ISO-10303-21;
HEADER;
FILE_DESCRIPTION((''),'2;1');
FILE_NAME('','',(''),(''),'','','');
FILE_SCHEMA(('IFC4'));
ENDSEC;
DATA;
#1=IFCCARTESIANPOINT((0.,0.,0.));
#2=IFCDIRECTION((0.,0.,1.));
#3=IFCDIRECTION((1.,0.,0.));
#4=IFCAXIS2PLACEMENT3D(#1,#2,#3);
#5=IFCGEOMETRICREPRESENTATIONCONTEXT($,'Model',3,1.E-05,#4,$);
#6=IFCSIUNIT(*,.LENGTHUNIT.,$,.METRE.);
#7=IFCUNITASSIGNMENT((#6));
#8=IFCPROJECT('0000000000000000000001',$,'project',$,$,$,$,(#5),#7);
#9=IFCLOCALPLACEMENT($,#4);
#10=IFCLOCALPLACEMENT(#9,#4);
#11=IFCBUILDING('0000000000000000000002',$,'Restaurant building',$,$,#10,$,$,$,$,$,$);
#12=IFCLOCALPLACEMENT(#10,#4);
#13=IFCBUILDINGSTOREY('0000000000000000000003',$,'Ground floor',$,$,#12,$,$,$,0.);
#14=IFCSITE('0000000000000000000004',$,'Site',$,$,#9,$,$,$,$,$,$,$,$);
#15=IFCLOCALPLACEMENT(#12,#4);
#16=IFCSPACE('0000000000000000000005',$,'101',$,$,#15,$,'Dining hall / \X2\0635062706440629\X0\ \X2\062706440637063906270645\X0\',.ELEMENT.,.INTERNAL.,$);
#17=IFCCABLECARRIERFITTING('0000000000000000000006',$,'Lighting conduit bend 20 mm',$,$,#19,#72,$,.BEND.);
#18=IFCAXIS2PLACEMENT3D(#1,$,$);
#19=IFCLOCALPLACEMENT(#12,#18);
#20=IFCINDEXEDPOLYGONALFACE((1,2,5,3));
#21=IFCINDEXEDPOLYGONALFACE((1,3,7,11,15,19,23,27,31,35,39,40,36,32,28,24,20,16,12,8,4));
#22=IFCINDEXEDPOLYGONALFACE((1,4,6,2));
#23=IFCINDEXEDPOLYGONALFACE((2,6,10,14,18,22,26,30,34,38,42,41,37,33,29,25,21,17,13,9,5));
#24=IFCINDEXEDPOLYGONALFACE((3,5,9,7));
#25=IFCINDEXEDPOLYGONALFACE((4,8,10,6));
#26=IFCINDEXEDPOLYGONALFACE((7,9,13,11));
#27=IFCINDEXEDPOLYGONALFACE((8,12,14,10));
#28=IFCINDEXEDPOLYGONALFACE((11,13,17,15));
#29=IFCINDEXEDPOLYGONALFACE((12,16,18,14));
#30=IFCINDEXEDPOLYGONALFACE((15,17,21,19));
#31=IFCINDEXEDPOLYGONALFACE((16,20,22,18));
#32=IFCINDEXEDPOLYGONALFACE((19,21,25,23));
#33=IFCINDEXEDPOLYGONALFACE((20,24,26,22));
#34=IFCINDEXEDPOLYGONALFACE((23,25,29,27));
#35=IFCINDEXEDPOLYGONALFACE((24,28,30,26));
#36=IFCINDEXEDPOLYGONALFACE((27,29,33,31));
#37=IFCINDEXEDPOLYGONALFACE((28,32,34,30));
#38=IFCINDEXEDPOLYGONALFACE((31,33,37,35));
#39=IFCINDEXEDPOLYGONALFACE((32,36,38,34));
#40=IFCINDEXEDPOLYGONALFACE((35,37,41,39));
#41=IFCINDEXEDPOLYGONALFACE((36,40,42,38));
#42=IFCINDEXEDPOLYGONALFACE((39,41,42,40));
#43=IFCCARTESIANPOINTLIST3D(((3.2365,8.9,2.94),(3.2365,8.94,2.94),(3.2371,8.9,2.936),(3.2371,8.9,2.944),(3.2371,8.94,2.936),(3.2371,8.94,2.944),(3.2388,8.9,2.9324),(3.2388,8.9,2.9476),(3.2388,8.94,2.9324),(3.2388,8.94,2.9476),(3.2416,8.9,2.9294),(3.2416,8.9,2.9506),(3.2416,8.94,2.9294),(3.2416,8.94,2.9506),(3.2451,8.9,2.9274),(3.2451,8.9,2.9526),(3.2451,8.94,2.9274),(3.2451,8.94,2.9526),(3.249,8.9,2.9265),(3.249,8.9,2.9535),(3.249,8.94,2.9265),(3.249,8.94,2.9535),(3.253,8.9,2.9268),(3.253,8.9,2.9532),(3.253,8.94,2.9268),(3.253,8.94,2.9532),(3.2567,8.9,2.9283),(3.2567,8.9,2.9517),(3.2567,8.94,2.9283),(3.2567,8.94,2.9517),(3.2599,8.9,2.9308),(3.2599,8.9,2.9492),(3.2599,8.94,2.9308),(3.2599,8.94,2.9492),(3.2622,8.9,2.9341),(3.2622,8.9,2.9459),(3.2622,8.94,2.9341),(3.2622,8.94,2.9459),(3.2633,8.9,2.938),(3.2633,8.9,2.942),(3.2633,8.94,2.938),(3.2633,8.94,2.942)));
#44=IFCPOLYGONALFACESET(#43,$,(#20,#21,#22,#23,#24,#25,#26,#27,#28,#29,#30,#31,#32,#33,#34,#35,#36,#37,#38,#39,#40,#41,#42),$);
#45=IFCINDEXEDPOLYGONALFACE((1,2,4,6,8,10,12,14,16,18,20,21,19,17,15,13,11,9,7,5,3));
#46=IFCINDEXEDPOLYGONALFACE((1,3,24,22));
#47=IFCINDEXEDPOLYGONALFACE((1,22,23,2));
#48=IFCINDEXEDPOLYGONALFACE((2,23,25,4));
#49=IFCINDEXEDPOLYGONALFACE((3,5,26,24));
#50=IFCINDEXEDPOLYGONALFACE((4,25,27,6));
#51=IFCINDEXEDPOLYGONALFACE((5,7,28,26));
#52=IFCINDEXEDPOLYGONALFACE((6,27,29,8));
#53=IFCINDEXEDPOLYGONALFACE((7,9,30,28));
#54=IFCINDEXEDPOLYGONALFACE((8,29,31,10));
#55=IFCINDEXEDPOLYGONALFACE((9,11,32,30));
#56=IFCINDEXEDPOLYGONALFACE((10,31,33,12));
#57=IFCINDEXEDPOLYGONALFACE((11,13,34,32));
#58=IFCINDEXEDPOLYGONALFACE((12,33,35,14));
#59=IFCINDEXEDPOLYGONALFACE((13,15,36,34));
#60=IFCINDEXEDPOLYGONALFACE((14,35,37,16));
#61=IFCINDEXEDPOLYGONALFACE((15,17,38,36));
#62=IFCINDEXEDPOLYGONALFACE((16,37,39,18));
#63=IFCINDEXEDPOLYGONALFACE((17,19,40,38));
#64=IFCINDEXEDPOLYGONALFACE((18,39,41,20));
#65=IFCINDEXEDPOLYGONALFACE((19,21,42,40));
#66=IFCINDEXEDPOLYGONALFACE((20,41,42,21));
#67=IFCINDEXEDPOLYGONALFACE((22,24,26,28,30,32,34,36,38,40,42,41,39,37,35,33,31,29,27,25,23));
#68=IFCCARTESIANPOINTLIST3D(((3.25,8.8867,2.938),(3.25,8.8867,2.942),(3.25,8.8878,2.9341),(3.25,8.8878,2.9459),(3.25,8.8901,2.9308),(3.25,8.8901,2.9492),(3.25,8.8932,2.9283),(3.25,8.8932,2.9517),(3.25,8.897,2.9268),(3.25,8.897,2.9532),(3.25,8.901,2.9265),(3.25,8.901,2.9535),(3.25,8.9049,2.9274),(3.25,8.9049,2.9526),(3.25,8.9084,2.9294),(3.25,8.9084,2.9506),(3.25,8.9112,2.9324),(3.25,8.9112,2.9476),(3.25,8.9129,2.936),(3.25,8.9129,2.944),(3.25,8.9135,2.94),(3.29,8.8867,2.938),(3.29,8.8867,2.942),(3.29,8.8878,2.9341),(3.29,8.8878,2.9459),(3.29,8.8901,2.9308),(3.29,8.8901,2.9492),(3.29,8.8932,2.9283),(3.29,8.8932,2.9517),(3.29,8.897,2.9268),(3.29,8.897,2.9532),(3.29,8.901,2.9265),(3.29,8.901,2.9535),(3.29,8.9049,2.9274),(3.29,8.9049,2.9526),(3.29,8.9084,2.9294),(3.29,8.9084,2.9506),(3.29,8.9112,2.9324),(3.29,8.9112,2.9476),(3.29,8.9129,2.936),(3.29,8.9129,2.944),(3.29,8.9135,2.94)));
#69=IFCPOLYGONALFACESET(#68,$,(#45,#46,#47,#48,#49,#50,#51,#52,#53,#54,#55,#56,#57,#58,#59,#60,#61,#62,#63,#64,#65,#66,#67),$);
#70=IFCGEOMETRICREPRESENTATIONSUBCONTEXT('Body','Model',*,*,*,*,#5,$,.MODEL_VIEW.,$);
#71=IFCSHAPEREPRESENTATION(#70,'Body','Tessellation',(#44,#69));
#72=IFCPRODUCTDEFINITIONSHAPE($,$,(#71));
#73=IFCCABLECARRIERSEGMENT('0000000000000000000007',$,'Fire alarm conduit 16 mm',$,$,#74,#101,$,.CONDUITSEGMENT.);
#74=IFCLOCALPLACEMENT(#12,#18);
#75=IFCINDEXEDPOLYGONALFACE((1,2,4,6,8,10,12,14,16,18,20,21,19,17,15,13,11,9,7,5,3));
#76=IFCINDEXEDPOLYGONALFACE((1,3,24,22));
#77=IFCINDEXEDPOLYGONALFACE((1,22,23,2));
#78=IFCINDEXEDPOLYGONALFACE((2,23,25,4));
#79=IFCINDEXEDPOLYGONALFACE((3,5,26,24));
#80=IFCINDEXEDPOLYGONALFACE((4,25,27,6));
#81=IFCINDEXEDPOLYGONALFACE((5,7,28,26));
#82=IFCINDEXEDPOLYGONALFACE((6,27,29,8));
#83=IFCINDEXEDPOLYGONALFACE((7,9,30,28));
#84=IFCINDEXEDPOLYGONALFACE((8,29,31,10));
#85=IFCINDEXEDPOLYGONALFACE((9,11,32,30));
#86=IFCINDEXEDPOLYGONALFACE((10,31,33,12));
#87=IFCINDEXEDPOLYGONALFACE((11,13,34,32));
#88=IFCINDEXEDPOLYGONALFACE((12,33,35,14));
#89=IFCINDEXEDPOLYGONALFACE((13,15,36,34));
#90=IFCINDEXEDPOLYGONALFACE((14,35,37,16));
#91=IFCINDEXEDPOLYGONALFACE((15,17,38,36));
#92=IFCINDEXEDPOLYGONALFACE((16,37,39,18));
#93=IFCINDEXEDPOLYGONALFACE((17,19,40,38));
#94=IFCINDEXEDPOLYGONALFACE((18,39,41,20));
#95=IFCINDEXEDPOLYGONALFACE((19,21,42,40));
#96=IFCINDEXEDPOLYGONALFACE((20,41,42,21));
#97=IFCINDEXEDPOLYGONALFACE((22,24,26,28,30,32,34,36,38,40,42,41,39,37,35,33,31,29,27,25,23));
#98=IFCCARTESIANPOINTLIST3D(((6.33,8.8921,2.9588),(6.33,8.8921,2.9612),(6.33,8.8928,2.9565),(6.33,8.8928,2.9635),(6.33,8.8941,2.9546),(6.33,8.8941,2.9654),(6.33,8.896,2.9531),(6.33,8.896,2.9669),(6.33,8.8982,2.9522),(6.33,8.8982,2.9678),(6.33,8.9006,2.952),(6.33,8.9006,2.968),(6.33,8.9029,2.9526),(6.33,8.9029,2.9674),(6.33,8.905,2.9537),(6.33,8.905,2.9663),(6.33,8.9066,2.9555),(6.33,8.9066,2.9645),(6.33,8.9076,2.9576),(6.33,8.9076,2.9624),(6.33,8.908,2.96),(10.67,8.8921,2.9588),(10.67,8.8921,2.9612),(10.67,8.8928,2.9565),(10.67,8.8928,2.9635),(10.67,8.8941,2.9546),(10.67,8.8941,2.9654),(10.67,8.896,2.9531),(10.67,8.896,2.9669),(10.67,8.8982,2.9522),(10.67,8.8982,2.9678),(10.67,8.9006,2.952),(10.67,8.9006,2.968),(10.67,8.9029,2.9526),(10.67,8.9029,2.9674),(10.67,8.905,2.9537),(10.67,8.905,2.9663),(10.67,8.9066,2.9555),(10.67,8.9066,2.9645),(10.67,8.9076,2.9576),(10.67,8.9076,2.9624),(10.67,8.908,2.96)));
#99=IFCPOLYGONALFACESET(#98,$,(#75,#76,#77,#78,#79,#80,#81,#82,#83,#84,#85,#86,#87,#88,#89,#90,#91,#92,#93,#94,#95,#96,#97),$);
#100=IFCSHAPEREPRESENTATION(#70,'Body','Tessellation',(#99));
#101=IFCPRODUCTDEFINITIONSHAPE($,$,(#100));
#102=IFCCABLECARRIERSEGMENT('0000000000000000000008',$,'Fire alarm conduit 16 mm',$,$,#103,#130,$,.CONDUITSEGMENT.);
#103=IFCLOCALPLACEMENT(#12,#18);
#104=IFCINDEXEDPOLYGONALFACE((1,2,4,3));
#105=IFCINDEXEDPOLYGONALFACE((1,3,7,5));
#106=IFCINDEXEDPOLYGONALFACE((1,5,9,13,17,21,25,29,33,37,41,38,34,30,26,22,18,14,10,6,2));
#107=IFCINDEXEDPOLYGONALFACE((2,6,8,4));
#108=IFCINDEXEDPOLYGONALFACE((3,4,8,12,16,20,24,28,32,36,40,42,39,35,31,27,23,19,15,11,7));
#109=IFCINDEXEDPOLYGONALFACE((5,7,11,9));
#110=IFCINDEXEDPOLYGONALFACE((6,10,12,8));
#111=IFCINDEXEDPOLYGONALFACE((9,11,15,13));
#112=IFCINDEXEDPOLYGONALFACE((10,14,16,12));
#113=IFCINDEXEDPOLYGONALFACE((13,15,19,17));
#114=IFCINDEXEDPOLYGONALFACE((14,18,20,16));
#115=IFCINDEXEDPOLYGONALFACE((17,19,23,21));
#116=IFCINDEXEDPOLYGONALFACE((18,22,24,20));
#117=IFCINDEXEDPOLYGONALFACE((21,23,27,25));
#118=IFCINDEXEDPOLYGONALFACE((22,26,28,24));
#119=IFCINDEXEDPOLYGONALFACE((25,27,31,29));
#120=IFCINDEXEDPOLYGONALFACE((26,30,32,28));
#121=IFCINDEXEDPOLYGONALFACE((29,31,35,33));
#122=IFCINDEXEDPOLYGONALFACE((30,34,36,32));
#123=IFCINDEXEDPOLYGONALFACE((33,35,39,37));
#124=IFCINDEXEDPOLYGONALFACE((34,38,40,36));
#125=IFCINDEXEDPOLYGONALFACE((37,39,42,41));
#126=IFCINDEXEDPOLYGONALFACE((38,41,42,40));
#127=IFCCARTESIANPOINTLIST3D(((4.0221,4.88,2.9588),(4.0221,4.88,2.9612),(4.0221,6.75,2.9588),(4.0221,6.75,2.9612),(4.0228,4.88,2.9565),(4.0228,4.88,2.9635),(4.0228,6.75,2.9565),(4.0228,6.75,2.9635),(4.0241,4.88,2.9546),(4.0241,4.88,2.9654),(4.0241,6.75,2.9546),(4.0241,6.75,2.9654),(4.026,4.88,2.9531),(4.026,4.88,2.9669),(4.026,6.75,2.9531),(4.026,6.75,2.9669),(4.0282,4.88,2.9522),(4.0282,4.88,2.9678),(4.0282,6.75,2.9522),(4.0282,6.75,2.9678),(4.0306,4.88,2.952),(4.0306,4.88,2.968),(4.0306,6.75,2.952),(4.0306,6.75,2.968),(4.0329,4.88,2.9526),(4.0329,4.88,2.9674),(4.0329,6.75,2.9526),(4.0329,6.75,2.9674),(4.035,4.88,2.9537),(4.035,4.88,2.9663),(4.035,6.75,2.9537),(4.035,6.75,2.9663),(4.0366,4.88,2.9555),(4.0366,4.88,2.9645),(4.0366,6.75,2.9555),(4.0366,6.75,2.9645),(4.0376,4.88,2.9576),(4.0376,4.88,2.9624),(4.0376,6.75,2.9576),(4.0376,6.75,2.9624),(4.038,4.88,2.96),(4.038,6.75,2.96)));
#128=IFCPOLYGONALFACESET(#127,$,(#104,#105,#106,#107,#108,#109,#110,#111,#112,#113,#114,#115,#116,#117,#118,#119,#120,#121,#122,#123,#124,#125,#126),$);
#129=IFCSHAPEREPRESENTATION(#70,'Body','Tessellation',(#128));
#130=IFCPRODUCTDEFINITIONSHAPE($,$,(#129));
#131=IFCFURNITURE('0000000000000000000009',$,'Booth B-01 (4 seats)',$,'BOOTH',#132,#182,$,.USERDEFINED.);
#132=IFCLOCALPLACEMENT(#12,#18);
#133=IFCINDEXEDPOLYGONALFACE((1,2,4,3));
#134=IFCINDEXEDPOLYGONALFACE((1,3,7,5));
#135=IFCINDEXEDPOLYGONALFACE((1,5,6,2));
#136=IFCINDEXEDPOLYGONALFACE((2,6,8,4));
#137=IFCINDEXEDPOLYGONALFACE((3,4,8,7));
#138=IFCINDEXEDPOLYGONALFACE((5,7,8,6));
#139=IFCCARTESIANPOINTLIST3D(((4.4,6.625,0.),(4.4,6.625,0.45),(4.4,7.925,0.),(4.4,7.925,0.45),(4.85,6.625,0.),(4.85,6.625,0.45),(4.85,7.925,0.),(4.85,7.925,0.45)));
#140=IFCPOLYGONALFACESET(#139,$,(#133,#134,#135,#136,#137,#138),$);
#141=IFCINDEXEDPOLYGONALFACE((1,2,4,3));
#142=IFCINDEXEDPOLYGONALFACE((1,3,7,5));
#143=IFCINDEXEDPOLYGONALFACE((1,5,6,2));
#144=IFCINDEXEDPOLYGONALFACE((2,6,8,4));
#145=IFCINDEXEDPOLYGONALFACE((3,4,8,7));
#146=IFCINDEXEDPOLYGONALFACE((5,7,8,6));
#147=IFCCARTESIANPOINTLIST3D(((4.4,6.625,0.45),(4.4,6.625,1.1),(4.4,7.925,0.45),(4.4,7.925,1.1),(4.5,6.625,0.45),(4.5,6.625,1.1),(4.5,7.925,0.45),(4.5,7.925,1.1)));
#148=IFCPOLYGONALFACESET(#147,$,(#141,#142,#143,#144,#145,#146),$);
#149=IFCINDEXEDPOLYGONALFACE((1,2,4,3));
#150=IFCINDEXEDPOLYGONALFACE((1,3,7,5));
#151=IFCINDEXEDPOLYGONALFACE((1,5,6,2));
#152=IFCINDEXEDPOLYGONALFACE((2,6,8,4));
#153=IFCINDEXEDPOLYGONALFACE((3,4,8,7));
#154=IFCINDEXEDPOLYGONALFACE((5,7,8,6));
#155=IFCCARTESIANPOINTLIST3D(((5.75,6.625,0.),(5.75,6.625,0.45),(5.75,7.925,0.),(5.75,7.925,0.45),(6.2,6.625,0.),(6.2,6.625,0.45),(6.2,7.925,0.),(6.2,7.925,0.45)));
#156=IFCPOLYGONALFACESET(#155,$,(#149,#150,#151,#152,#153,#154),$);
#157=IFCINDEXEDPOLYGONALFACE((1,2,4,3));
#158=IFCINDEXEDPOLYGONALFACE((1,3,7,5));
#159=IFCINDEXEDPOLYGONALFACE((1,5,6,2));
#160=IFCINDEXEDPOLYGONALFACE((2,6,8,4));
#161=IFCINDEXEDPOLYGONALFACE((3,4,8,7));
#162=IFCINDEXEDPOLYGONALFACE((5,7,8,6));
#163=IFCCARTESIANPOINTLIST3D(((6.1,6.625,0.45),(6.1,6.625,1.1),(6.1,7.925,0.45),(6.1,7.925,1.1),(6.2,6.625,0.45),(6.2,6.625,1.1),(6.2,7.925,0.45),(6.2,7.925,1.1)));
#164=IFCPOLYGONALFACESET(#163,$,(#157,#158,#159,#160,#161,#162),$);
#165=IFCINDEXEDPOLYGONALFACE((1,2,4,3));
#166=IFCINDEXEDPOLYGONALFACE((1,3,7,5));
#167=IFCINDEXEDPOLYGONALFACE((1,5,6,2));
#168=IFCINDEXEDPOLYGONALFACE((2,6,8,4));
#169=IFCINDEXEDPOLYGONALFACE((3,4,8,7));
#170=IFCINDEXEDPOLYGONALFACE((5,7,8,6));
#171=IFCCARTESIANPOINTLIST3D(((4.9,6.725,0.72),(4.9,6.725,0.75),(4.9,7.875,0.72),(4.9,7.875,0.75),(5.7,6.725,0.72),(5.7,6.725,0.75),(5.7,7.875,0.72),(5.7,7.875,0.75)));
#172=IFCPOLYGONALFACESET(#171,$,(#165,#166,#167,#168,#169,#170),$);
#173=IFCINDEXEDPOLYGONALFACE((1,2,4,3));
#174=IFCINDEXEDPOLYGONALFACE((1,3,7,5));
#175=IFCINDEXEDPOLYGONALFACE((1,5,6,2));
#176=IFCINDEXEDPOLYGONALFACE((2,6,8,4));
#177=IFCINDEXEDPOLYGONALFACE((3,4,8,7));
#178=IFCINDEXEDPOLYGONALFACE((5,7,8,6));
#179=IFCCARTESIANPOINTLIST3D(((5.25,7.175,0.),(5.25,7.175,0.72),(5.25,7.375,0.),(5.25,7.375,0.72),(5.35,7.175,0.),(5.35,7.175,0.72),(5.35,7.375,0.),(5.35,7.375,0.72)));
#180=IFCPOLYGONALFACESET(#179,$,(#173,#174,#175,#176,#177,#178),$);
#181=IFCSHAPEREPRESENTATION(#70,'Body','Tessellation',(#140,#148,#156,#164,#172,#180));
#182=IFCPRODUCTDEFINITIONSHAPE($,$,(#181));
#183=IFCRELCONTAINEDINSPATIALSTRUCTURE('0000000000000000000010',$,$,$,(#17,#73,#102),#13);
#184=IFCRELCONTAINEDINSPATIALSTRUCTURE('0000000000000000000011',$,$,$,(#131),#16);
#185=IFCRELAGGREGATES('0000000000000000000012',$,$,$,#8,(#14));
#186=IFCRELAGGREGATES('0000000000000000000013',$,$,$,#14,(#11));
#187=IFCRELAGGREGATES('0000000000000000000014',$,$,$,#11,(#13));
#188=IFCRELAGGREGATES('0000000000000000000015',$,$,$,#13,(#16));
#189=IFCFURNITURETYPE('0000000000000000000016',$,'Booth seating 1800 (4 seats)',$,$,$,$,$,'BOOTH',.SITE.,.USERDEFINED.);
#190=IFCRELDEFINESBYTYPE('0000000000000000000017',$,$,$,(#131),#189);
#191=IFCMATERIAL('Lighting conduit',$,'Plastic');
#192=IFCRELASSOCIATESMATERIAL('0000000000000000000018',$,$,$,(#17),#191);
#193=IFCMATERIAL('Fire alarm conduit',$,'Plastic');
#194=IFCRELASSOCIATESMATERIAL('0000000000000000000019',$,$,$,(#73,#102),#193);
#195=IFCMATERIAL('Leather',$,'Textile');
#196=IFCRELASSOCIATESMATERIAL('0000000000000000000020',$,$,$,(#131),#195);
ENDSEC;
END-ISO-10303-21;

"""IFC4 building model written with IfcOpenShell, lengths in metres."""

from ifc_helpers import new_model, si_unit, frame, origin, origin_with_axes, origin_2d, place, context, subcontext, project, spatial, rectangle, circle, extrude, source, transform, mapped, material, type_object, type_shapes, element, save


model = new_model("IFC4")

# Units and contexts
model_context = context("Model", 3, precision=1e-05, world=origin_with_axes())
body_context = subcontext(model_context, "Body", "Model", "MODEL_VIEW")
ifc_project = project(units=[si_unit("LENGTHUNIT", "METRE")], contexts=[model_context])

# Site, building, storey
site_placement = place(None, origin_with_axes())
site = spatial("IfcSite", under=ifc_project, at=site_placement, Name="Site")
building_placement = place(site_placement, origin_with_axes())
building = spatial("IfcBuilding", under=site, at=building_placement, Name="Restaurant building")
storey_placement = place(building_placement, origin_with_axes())
storey = spatial("IfcBuildingStorey", under=building, at=storey_placement, Name="Ground floor", Elevation=0.0)

# Shared definitions
space_1_placement = place(storey_placement, origin_with_axes())
space_1 = spatial("IfcSpace", under=storey, at=space_1_placement, Name="101", LongName="Dining hall / صالة الطعام", CompositionType="ELEMENT", PredefinedType="INTERNAL")

# Shared definitions
ifc_material_1 = material(Name="Lighting conduit", Category="Plastic")

# Cable carrier fitting
cable_carrier_fitting_1_placement = place(storey_placement, frame((3.25, 8.9, 2.94)))
element("IfcCableCarrierFitting", 1, at=cable_carrier_fitting_1_placement, inside=storey, material=ifc_material_1, Name="Lighting conduit bend 20 mm", PredefinedType="BEND", context=body_context, shape_type="SweptSolid", body=[
    extrude(circle(Radius=0.0135, at=origin_2d()), frame((0.0, 0.0, 0.0), z_axis=(0.0, 1.0, 0.0), x_axis=(-1.0, 0.0, 0.0)), (0.0, 0.0, 1.0), 0.04),
    extrude(circle(Radius=0.0135, at=origin_2d()), frame((0.0, 0.0, 0.0), z_axis=(1.0, 0.0, 0.0), x_axis=(0.0, 1.0, 0.0)), (0.0, 0.0, 1.0), 0.04),
])

# Cable carrier segments
ifc_material_2 = material(Name="Fire alarm conduit", Category="Plastic")
cable_carrier_segment_1_placement = place(storey_placement, frame((6.33, 8.9, 2.96)))
element("IfcCableCarrierSegment", 2, at=cable_carrier_segment_1_placement, inside=storey, material=ifc_material_2, Name="Fire alarm conduit 16 mm", PredefinedType="CONDUITSEGMENT", context=body_context, shape_type="SweptSolid", body=[
    extrude(circle(Radius=0.008, at=origin_2d()), frame((0.0, 0.0, 0.0), z_axis=(1.0, 0.0, 0.0), x_axis=(0.0, 1.0, 0.0)), (0.0, 0.0, 1.0), 4.34),
])
cable_carrier_segment_2_placement = place(storey_placement, frame((4.03, 6.75, 2.96)))
element("IfcCableCarrierSegment", 3, at=cable_carrier_segment_2_placement, inside=storey, material=ifc_material_2, Name="Fire alarm conduit 16 mm", PredefinedType="CONDUITSEGMENT", context=body_context, shape_type="SweptSolid", body=[
    extrude(circle(Radius=0.008, at=origin_2d()), frame((0.0, 0.0, 0.0), z_axis=(0.0, -1.0, 0.0), x_axis=(1.0, 0.0, 0.0)), (0.0, 0.0, 1.0), 1.87),
])

# Furniture
ifc_material_3 = material(Name="Leather", Category="Textile")
furniture_type_1 = type_object("IfcFurnitureType", Name="Booth seating 1800 (4 seats)", ElementType="BOOTH", AssemblyPlace="SITE", PredefinedType="USERDEFINED")
shared_shape_1 = source(origin(), body_context, "Body", "SweptSolid", [
    extrude(rectangle(XDim=0.45, YDim=1.3, at=origin_2d()), frame((-0.675, -0.65, 0.0)), (0.0, 0.0, 1.0), 0.45),
    extrude(rectangle(XDim=0.1, YDim=1.3, at=origin_2d()), frame((-0.85, -0.65, 0.45)), (0.0, 0.0, 1.0), 0.65),
    extrude(rectangle(XDim=0.45, YDim=1.3, at=origin_2d()), frame((0.675, -0.65, 0.0)), (0.0, 0.0, 1.0), 0.45),
    extrude(rectangle(XDim=0.1, YDim=1.3, at=origin_2d()), frame((0.85, -0.65, 0.45)), (0.0, 0.0, 1.0), 0.65),
    extrude(rectangle(XDim=0.8, YDim=1.15, at=origin_2d()), frame((0.0, -0.625, 0.72)), (0.0, 0.0, 1.0), 0.03),
    extrude(rectangle(XDim=0.1, YDim=0.2, at=origin_2d()), frame((0.0, -0.65, 0.0)), (0.0, 0.0, 1.0), 0.72),
])
type_shapes(furniture_type_1, [shared_shape_1])
furniture_1_placement = place(storey_placement, frame((5.3, 7.925, 0.0)))
element("IfcFurniture", 4, at=furniture_1_placement, inside=space_1, type_object=furniture_type_1, material=ifc_material_3, Name="Booth B-01 (4 seats)", ObjectType="BOOTH", PredefinedType="USERDEFINED", context=body_context, shape_type="MappedRepresentation", body=[
    mapped(shared_shape_1, transform((0.0, 0.0, 0.0))),
])

save(model, "model.ifc")
